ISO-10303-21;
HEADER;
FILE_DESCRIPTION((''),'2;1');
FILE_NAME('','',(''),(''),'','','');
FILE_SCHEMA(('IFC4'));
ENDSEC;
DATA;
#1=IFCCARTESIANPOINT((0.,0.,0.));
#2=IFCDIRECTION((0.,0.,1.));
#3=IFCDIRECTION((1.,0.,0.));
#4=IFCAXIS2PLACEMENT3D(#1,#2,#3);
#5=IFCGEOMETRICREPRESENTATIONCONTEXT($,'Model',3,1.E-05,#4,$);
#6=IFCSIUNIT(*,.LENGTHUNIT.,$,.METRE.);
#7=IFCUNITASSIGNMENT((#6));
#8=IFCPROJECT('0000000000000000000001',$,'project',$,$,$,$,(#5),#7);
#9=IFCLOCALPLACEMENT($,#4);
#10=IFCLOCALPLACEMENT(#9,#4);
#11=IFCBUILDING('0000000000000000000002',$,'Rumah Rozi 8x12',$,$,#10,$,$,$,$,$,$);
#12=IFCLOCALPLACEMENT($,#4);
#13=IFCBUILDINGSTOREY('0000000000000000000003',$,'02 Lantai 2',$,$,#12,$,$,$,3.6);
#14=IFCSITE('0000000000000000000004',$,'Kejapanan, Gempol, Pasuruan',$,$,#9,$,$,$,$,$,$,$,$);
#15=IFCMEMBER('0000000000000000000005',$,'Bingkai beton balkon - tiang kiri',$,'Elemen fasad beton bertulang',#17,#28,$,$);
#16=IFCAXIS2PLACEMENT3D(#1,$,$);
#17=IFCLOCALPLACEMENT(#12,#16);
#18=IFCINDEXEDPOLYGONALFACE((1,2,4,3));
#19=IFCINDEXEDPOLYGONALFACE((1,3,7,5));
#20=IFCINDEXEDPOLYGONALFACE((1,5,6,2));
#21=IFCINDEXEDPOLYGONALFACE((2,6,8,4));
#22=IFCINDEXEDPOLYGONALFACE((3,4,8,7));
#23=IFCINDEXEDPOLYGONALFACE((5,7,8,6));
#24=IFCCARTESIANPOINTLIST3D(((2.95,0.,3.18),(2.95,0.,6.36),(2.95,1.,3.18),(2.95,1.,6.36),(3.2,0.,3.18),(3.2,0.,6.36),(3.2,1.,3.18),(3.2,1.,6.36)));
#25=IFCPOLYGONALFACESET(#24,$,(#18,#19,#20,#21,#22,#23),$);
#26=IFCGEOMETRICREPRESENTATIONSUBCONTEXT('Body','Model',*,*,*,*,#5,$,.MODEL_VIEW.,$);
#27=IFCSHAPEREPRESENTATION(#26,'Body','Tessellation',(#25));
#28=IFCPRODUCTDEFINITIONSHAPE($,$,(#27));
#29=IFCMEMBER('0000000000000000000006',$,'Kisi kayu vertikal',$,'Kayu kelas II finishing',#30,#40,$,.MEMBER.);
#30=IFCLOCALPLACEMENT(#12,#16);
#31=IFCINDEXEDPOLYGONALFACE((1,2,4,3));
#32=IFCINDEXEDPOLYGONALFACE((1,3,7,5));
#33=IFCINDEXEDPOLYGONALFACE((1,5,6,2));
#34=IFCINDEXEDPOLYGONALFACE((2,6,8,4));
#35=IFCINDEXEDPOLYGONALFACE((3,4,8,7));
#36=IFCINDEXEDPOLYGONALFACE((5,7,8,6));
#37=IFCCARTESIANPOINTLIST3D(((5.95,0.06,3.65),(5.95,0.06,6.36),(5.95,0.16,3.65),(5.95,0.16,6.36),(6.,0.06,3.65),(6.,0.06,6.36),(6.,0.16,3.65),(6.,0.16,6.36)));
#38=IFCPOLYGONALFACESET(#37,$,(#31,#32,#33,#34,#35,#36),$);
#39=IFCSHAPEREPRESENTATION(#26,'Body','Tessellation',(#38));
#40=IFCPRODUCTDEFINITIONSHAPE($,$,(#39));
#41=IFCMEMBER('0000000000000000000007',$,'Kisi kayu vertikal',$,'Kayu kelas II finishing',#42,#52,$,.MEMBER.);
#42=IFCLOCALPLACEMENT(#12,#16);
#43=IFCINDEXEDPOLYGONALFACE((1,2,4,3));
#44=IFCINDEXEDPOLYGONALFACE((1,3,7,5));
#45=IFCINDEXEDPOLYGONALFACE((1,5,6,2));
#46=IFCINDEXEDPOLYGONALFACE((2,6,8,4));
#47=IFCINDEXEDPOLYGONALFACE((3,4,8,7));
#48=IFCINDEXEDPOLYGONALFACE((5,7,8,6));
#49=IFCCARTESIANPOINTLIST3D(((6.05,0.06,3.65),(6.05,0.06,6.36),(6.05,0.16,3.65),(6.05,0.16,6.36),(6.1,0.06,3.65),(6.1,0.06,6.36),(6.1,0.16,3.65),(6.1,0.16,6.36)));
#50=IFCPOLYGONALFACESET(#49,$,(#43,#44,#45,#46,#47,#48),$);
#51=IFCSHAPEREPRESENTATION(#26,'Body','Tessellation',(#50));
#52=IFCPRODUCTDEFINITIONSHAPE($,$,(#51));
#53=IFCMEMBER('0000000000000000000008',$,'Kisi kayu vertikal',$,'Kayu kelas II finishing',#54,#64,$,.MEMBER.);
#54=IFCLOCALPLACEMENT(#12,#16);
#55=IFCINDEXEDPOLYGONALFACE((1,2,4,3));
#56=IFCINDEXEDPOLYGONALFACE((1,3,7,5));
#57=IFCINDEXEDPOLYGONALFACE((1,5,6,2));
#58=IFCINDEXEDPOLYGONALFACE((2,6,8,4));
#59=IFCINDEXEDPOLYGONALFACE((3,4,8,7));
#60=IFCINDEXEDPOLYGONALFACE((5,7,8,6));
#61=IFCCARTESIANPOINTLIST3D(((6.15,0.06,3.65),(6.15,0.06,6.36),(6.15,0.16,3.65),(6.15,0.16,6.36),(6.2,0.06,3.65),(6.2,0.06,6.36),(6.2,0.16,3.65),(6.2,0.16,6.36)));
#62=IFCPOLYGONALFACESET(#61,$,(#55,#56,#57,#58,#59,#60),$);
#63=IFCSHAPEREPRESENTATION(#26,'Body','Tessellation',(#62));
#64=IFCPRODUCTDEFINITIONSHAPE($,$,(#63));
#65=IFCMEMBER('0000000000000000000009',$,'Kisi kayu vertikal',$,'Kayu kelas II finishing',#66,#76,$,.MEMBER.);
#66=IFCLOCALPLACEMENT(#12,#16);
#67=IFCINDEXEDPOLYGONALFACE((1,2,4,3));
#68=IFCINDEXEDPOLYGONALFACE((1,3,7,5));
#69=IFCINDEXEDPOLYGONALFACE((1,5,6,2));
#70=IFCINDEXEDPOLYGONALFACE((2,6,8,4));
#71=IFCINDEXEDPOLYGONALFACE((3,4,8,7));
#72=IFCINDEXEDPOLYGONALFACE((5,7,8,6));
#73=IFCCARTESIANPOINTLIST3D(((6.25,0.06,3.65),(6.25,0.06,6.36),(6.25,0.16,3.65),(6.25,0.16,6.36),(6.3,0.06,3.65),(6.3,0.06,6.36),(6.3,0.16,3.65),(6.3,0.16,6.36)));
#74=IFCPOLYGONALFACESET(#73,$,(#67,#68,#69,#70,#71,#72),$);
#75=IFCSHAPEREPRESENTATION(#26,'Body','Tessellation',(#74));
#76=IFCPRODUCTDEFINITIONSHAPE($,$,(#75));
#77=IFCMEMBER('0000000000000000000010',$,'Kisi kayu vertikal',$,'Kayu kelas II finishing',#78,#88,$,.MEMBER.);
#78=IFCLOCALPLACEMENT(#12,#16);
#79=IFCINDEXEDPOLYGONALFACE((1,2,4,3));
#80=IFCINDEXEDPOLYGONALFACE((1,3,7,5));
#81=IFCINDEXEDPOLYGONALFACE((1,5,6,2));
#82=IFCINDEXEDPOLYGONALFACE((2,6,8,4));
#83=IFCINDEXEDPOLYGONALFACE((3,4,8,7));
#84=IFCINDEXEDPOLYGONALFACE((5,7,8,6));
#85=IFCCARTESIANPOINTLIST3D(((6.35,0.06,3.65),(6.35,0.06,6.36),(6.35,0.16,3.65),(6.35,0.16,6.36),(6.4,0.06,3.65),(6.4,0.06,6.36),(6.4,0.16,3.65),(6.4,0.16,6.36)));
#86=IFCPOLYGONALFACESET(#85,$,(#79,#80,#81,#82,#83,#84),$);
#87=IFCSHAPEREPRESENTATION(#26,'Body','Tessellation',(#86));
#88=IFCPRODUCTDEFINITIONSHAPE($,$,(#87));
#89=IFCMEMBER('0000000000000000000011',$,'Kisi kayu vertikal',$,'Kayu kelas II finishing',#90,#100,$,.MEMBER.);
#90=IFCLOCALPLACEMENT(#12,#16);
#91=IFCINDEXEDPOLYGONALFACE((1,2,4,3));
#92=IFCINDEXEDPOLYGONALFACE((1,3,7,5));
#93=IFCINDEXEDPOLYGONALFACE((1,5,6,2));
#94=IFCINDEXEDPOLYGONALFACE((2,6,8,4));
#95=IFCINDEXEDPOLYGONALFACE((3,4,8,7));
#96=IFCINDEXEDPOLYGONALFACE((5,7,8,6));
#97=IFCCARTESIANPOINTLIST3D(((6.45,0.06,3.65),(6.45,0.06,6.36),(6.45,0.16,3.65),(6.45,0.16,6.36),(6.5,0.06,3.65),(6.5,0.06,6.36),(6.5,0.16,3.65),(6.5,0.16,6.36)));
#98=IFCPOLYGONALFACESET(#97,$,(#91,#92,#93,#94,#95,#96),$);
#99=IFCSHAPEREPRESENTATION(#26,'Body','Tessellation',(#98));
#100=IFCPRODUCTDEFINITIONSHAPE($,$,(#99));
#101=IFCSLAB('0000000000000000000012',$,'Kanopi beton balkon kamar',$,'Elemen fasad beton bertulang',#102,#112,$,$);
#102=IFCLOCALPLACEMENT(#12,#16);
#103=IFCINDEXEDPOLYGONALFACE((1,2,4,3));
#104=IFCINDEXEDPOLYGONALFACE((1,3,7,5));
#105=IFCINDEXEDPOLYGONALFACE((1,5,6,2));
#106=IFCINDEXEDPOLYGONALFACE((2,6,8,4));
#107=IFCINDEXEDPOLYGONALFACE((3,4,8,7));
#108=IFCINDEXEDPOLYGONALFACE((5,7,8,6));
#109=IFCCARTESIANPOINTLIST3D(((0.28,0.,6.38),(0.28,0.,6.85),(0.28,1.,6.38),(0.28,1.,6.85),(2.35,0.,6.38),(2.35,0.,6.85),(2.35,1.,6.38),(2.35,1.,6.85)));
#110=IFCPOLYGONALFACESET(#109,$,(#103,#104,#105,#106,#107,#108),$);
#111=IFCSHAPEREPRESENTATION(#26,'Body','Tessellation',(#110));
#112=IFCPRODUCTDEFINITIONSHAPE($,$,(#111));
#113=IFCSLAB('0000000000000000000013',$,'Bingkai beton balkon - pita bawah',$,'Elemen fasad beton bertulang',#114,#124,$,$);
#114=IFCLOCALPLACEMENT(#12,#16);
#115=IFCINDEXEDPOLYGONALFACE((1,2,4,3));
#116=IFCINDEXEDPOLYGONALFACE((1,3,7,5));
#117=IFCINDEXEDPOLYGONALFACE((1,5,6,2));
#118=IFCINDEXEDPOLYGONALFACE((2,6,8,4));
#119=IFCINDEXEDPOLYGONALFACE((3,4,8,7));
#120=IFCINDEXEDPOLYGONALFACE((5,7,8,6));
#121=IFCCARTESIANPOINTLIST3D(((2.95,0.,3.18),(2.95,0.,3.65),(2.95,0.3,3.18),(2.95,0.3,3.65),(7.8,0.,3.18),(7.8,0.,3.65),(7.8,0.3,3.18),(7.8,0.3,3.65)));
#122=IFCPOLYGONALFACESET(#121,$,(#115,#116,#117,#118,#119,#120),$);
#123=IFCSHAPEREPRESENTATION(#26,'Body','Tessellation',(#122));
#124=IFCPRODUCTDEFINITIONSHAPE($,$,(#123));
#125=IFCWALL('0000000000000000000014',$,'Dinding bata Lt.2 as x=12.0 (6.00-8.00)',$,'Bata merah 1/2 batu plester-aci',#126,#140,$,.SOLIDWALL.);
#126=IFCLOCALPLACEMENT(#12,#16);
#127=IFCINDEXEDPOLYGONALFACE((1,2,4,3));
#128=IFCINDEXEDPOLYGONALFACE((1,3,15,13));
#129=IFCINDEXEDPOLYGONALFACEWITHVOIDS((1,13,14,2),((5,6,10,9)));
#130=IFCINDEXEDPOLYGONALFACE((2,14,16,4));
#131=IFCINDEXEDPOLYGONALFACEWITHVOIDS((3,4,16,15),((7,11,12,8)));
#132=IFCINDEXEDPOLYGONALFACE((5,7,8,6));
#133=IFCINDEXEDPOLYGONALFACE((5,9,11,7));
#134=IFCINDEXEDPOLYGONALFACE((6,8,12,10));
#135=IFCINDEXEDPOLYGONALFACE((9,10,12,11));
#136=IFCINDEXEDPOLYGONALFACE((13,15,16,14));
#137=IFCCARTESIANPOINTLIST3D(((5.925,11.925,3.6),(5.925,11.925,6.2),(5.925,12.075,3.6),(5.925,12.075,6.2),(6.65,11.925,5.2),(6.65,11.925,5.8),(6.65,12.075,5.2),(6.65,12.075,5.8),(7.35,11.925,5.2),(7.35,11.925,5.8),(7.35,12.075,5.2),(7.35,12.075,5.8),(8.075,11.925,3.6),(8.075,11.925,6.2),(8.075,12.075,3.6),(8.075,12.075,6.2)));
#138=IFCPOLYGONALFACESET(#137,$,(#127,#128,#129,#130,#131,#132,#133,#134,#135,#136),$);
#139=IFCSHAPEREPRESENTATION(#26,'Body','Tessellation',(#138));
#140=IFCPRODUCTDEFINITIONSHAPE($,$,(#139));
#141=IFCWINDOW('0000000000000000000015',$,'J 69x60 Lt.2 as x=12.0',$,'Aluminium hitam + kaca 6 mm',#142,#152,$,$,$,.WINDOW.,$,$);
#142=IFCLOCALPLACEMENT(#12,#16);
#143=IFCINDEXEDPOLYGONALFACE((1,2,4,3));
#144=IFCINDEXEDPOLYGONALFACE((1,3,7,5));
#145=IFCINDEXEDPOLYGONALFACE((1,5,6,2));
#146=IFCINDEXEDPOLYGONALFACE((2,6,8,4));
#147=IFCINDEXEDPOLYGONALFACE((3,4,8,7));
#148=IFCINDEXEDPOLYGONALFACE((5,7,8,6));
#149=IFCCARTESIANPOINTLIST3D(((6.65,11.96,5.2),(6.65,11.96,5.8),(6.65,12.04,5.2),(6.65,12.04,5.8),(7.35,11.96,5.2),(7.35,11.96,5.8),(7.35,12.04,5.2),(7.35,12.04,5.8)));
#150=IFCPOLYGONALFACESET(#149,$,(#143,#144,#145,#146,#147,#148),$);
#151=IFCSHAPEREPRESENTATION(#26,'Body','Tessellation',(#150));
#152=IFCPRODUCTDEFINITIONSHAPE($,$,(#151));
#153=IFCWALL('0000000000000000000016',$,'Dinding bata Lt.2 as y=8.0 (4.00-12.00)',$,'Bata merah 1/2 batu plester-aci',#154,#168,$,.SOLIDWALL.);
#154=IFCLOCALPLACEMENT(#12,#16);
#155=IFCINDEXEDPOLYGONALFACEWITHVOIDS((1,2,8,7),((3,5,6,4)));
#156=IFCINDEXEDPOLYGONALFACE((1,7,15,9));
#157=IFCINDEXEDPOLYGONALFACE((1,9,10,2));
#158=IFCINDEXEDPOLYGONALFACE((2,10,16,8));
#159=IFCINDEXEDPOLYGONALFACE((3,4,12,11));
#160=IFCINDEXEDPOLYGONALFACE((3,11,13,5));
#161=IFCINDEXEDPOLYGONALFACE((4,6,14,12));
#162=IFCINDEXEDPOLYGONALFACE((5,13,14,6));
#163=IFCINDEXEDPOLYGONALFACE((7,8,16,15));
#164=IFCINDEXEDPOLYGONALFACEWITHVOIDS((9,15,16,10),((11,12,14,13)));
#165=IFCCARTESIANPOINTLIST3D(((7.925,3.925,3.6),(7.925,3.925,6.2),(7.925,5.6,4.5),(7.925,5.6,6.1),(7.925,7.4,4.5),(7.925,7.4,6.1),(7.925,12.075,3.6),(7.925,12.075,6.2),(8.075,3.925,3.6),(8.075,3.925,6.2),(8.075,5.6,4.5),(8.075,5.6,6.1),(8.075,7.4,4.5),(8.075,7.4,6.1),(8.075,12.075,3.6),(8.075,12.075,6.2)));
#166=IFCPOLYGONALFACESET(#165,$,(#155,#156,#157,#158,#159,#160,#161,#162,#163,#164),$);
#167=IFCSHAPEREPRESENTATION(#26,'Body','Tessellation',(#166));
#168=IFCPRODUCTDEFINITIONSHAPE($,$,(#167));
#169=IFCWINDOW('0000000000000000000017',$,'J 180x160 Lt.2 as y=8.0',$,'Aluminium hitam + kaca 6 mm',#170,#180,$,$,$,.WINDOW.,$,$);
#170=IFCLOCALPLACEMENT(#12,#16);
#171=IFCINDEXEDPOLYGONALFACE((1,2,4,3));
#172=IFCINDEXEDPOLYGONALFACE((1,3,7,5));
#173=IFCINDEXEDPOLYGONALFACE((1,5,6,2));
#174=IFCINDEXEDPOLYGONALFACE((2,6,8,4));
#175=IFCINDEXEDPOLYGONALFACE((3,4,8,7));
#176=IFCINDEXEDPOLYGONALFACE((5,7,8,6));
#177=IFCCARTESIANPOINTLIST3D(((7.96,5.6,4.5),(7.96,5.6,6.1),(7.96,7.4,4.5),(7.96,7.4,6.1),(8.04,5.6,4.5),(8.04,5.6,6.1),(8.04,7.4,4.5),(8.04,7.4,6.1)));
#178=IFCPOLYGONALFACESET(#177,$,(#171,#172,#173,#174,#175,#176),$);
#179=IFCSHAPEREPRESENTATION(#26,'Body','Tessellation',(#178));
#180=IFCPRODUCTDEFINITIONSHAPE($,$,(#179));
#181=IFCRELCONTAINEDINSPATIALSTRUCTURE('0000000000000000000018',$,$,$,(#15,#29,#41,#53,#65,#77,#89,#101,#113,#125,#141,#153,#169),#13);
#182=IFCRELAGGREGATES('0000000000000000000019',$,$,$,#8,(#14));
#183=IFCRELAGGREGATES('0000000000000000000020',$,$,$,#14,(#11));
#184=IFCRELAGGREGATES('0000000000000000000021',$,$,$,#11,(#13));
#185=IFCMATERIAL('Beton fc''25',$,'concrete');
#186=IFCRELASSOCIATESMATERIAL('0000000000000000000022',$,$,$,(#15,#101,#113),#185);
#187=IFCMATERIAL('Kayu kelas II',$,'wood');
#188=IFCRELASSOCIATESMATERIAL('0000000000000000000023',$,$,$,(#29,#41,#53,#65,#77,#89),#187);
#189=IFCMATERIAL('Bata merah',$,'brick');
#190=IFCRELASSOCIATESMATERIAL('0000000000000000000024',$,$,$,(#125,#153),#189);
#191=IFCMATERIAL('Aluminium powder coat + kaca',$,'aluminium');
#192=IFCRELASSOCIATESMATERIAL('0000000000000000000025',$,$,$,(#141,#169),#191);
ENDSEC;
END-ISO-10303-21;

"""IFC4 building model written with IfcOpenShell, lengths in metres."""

from ifc_helpers import new_model, si_unit, frame, origin_with_axes, place, context, subcontext, project, spatial, line, indexed_curve, outline, extrude, material, element, fill, save


model = new_model("IFC4")

# Units and contexts
model_context = context("Model", 3, precision=1e-05, world=origin_with_axes())
body_context = subcontext(model_context, "Body", "Model", "MODEL_VIEW")
ifc_project = project(units=[si_unit("LENGTHUNIT", "METRE")], contexts=[model_context])

# Site, building, storey
site_placement = place(None, origin_with_axes())
site = spatial("IfcSite", under=ifc_project, at=site_placement, Name="Kejapanan, Gempol, Pasuruan")
building_placement = place(site_placement, origin_with_axes())
building = spatial("IfcBuilding", under=site, at=building_placement, Name="Rumah Rozi 8x12")
storey_placement = place(None, origin_with_axes())
storey = spatial("IfcBuildingStorey", under=building, at=storey_placement, Name="02 Lantai 2", Elevation=3.6)

# Members
ifc_material_1 = material(Name="Beton fc'25", Category="concrete")
member_1_placement = place(storey_placement, origin_with_axes())
element("IfcMember", 1, at=member_1_placement, inside=storey, material=ifc_material_1, Name="Bingkai beton balkon - tiang kiri", ObjectType="Elemen fasad beton bertulang", context=body_context, shape_type="SweptSolid", body=[
    extrude(outline(indexed_curve([(2.95, 0.0), (3.2, 0.0), (3.2, 1.0), (2.95, 1.0)], segments=[line(1, 2, 3, 4, 1)])), frame((0.0, 0.0, 3.18), z_axis=(0.0, 0.0, 1.0), x_axis=(1.0, 0.0, 0.0)), (0.0, 0.0, 1.0), 3.18),
])
ifc_material_2 = material(Name="Kayu kelas II", Category="wood")
member_2_placement = place(storey_placement, origin_with_axes())
element("IfcMember", 2, at=member_2_placement, inside=storey, material=ifc_material_2, Name="Kisi kayu vertikal", ObjectType="Kayu kelas II finishing", PredefinedType="MEMBER", context=body_context, shape_type="SweptSolid", body=[
    extrude(outline(indexed_curve([(5.95, 0.06), (6.0, 0.06), (6.0, 0.16), (5.95, 0.16)], segments=[line(1, 2, 3, 4, 1)])), frame((0.0, 0.0, 3.65), z_axis=(0.0, 0.0, 1.0), x_axis=(1.0, 0.0, 0.0)), (0.0, 0.0, 1.0), 2.71),
])
member_3_placement = place(storey_placement, origin_with_axes())
element("IfcMember", 3, at=member_3_placement, inside=storey, material=ifc_material_2, Name="Kisi kayu vertikal", ObjectType="Kayu kelas II finishing", PredefinedType="MEMBER", context=body_context, shape_type="SweptSolid", body=[
    extrude(outline(indexed_curve([(6.05, 0.06), (6.1, 0.06), (6.1, 0.16), (6.05, 0.16)], segments=[line(1, 2, 3, 4, 1)])), frame((0.0, 0.0, 3.65), z_axis=(0.0, 0.0, 1.0), x_axis=(1.0, 0.0, 0.0)), (0.0, 0.0, 1.0), 2.71),
])
member_4_placement = place(storey_placement, origin_with_axes())
element("IfcMember", 4, at=member_4_placement, inside=storey, material=ifc_material_2, Name="Kisi kayu vertikal", ObjectType="Kayu kelas II finishing", PredefinedType="MEMBER", context=body_context, shape_type="SweptSolid", body=[
    extrude(outline(indexed_curve([(6.15, 0.06), (6.2, 0.06), (6.2, 0.16), (6.15, 0.16)], segments=[line(1, 2, 3, 4, 1)])), frame((0.0, 0.0, 3.65), z_axis=(0.0, 0.0, 1.0), x_axis=(1.0, 0.0, 0.0)), (0.0, 0.0, 1.0), 2.71),
])
member_5_placement = place(storey_placement, origin_with_axes())
element("IfcMember", 5, at=member_5_placement, inside=storey, material=ifc_material_2, Name="Kisi kayu vertikal", ObjectType="Kayu kelas II finishing", PredefinedType="MEMBER", context=body_context, shape_type="SweptSolid", body=[
    extrude(outline(indexed_curve([(6.25, 0.06), (6.3, 0.06), (6.3, 0.16), (6.25, 0.16)], segments=[line(1, 2, 3, 4, 1)])), frame((0.0, 0.0, 3.65), z_axis=(0.0, 0.0, 1.0), x_axis=(1.0, 0.0, 0.0)), (0.0, 0.0, 1.0), 2.71),
])
member_6_placement = place(storey_placement, origin_with_axes())
element("IfcMember", 6, at=member_6_placement, inside=storey, material=ifc_material_2, Name="Kisi kayu vertikal", ObjectType="Kayu kelas II finishing", PredefinedType="MEMBER", context=body_context, shape_type="SweptSolid", body=[
    extrude(outline(indexed_curve([(6.35, 0.06), (6.4, 0.06), (6.4, 0.16), (6.35, 0.16)], segments=[line(1, 2, 3, 4, 1)])), frame((0.0, 0.0, 3.65), z_axis=(0.0, 0.0, 1.0), x_axis=(1.0, 0.0, 0.0)), (0.0, 0.0, 1.0), 2.71),
])
member_7_placement = place(storey_placement, origin_with_axes())
element("IfcMember", 7, at=member_7_placement, inside=storey, material=ifc_material_2, Name="Kisi kayu vertikal", ObjectType="Kayu kelas II finishing", PredefinedType="MEMBER", context=body_context, shape_type="SweptSolid", body=[
    extrude(outline(indexed_curve([(6.45, 0.06), (6.5, 0.06), (6.5, 0.16), (6.45, 0.16)], segments=[line(1, 2, 3, 4, 1)])), frame((0.0, 0.0, 3.65), z_axis=(0.0, 0.0, 1.0), x_axis=(1.0, 0.0, 0.0)), (0.0, 0.0, 1.0), 2.71),
])

# Slabs
slab_1_placement = place(storey_placement, origin_with_axes())
element("IfcSlab", 8, at=slab_1_placement, inside=storey, material=ifc_material_1, Name="Kanopi beton balkon kamar", ObjectType="Elemen fasad beton bertulang", context=body_context, shape_type="SweptSolid", body=[
    extrude(outline(indexed_curve([(0.28, 0.0), (2.35, 0.0), (2.35, 1.0), (0.28, 1.0)], segments=[line(1, 2, 3, 4, 1)])), frame((0.0, 0.0, 6.38), z_axis=(0.0, 0.0, 1.0), x_axis=(1.0, 0.0, 0.0)), (0.0, 0.0, 1.0), 0.47),
])
slab_2_placement = place(storey_placement, origin_with_axes())
element("IfcSlab", 9, at=slab_2_placement, inside=storey, material=ifc_material_1, Name="Bingkai beton balkon - pita bawah", ObjectType="Elemen fasad beton bertulang", context=body_context, shape_type="SweptSolid", body=[
    extrude(outline(indexed_curve([(2.95, 0.0), (7.8, 0.0), (7.8, 0.3), (2.95, 0.3)], segments=[line(1, 2, 3, 4, 1)])), frame((0.0, 0.0, 3.18), z_axis=(0.0, 0.0, 1.0), x_axis=(1.0, 0.0, 0.0)), (0.0, 0.0, 1.0), 0.47),
])

# Walls, openings, windows
ifc_material_3 = material(Name="Bata merah", Category="brick")
wall_1_placement = place(storey_placement, origin_with_axes())
wall_1 = element("IfcWall", 10, at=wall_1_placement, inside=storey, material=ifc_material_3, Name="Dinding bata Lt.2 as x=12.0 (6.00-8.00)", ObjectType="Bata merah 1/2 batu plester-aci", PredefinedType="SOLIDWALL", context=body_context, shape_type="SweptSolid", body=[
    extrude(outline(indexed_curve([(5.925, 11.925), (8.075, 11.925), (8.075, 12.075), (5.925, 12.075)], segments=[line(1, 2, 3, 4, 1)])), frame((0.0, 0.0, 3.6), z_axis=(0.0, 0.0, 1.0), x_axis=(1.0, 0.0, 0.0)), (0.0, 0.0, 1.0), 2.6),
])
opening_1_placement = place(wall_1_placement, origin_with_axes())
opening_1 = element("IfcOpeningElement", 11, at=opening_1_placement, cuts=wall_1, context=body_context, shape_type="SweptSolid", body=[
    extrude(outline(indexed_curve([(6.65, 11.915), (7.35, 11.915), (7.35, 12.085), (6.65, 12.085)], segments=[line(1, 2, 3, 4, 1)])), frame((0.0, 0.0, 5.2), z_axis=(0.0, 0.0, 1.0), x_axis=(1.0, 0.0, 0.0)), (0.0, 0.0, 1.0), 0.6),
])
ifc_material_4 = material(Name="Aluminium powder coat + kaca", Category="aluminium")
window_1_placement = place(storey_placement, origin_with_axes())
window_1 = element("IfcWindow", 12, at=window_1_placement, inside=storey, material=ifc_material_4, Name="J 69x60 Lt.2 as x=12.0", ObjectType="Aluminium hitam + kaca 6 mm", PredefinedType="WINDOW", context=body_context, shape_type="SweptSolid", body=[
    extrude(outline(indexed_curve([(6.65, 11.96), (7.35, 11.96), (7.35, 12.04), (6.65, 12.04)], segments=[line(1, 2, 3, 4, 1)])), frame((0.0, 0.0, 5.2), z_axis=(0.0, 0.0, 1.0), x_axis=(1.0, 0.0, 0.0)), (0.0, 0.0, 1.0), 0.6),
])
fill(opening_1, window_1)
wall_2_placement = place(storey_placement, origin_with_axes())
wall_2 = element("IfcWall", 13, at=wall_2_placement, inside=storey, material=ifc_material_3, Name="Dinding bata Lt.2 as y=8.0 (4.00-12.00)", ObjectType="Bata merah 1/2 batu plester-aci", PredefinedType="SOLIDWALL", context=body_context, shape_type="SweptSolid", body=[
    extrude(outline(indexed_curve([(7.925, 3.925), (8.075, 3.925), (8.075, 12.075), (7.925, 12.075)], segments=[line(1, 2, 3, 4, 1)])), frame((0.0, 0.0, 3.6), z_axis=(0.0, 0.0, 1.0), x_axis=(1.0, 0.0, 0.0)), (0.0, 0.0, 1.0), 2.6),
])
opening_2_placement = place(wall_2_placement, origin_with_axes())
opening_2 = element("IfcOpeningElement", 14, at=opening_2_placement, cuts=wall_2, context=body_context, shape_type="SweptSolid", body=[
    extrude(outline(indexed_curve([(7.915, 5.6), (8.085, 5.6), (8.085, 7.4), (7.915, 7.4)], segments=[line(1, 2, 3, 4, 1)])), frame((0.0, 0.0, 4.5), z_axis=(0.0, 0.0, 1.0), x_axis=(1.0, 0.0, 0.0)), (0.0, 0.0, 1.0), 1.6),
])
window_2_placement = place(storey_placement, origin_with_axes())
window_2 = element("IfcWindow", 15, at=window_2_placement, inside=storey, material=ifc_material_4, Name="J 180x160 Lt.2 as y=8.0", ObjectType="Aluminium hitam + kaca 6 mm", PredefinedType="WINDOW", context=body_context, shape_type="SweptSolid", body=[
    extrude(outline(indexed_curve([(7.96, 5.6), (8.04, 5.6), (8.04, 7.4), (7.96, 7.4)], segments=[line(1, 2, 3, 4, 1)])), frame((0.0, 0.0, 4.5), z_axis=(0.0, 0.0, 1.0), x_axis=(1.0, 0.0, 0.0)), (0.0, 0.0, 1.0), 1.6),
])
fill(opening_2, window_2)

save(model, "model.ifc")
